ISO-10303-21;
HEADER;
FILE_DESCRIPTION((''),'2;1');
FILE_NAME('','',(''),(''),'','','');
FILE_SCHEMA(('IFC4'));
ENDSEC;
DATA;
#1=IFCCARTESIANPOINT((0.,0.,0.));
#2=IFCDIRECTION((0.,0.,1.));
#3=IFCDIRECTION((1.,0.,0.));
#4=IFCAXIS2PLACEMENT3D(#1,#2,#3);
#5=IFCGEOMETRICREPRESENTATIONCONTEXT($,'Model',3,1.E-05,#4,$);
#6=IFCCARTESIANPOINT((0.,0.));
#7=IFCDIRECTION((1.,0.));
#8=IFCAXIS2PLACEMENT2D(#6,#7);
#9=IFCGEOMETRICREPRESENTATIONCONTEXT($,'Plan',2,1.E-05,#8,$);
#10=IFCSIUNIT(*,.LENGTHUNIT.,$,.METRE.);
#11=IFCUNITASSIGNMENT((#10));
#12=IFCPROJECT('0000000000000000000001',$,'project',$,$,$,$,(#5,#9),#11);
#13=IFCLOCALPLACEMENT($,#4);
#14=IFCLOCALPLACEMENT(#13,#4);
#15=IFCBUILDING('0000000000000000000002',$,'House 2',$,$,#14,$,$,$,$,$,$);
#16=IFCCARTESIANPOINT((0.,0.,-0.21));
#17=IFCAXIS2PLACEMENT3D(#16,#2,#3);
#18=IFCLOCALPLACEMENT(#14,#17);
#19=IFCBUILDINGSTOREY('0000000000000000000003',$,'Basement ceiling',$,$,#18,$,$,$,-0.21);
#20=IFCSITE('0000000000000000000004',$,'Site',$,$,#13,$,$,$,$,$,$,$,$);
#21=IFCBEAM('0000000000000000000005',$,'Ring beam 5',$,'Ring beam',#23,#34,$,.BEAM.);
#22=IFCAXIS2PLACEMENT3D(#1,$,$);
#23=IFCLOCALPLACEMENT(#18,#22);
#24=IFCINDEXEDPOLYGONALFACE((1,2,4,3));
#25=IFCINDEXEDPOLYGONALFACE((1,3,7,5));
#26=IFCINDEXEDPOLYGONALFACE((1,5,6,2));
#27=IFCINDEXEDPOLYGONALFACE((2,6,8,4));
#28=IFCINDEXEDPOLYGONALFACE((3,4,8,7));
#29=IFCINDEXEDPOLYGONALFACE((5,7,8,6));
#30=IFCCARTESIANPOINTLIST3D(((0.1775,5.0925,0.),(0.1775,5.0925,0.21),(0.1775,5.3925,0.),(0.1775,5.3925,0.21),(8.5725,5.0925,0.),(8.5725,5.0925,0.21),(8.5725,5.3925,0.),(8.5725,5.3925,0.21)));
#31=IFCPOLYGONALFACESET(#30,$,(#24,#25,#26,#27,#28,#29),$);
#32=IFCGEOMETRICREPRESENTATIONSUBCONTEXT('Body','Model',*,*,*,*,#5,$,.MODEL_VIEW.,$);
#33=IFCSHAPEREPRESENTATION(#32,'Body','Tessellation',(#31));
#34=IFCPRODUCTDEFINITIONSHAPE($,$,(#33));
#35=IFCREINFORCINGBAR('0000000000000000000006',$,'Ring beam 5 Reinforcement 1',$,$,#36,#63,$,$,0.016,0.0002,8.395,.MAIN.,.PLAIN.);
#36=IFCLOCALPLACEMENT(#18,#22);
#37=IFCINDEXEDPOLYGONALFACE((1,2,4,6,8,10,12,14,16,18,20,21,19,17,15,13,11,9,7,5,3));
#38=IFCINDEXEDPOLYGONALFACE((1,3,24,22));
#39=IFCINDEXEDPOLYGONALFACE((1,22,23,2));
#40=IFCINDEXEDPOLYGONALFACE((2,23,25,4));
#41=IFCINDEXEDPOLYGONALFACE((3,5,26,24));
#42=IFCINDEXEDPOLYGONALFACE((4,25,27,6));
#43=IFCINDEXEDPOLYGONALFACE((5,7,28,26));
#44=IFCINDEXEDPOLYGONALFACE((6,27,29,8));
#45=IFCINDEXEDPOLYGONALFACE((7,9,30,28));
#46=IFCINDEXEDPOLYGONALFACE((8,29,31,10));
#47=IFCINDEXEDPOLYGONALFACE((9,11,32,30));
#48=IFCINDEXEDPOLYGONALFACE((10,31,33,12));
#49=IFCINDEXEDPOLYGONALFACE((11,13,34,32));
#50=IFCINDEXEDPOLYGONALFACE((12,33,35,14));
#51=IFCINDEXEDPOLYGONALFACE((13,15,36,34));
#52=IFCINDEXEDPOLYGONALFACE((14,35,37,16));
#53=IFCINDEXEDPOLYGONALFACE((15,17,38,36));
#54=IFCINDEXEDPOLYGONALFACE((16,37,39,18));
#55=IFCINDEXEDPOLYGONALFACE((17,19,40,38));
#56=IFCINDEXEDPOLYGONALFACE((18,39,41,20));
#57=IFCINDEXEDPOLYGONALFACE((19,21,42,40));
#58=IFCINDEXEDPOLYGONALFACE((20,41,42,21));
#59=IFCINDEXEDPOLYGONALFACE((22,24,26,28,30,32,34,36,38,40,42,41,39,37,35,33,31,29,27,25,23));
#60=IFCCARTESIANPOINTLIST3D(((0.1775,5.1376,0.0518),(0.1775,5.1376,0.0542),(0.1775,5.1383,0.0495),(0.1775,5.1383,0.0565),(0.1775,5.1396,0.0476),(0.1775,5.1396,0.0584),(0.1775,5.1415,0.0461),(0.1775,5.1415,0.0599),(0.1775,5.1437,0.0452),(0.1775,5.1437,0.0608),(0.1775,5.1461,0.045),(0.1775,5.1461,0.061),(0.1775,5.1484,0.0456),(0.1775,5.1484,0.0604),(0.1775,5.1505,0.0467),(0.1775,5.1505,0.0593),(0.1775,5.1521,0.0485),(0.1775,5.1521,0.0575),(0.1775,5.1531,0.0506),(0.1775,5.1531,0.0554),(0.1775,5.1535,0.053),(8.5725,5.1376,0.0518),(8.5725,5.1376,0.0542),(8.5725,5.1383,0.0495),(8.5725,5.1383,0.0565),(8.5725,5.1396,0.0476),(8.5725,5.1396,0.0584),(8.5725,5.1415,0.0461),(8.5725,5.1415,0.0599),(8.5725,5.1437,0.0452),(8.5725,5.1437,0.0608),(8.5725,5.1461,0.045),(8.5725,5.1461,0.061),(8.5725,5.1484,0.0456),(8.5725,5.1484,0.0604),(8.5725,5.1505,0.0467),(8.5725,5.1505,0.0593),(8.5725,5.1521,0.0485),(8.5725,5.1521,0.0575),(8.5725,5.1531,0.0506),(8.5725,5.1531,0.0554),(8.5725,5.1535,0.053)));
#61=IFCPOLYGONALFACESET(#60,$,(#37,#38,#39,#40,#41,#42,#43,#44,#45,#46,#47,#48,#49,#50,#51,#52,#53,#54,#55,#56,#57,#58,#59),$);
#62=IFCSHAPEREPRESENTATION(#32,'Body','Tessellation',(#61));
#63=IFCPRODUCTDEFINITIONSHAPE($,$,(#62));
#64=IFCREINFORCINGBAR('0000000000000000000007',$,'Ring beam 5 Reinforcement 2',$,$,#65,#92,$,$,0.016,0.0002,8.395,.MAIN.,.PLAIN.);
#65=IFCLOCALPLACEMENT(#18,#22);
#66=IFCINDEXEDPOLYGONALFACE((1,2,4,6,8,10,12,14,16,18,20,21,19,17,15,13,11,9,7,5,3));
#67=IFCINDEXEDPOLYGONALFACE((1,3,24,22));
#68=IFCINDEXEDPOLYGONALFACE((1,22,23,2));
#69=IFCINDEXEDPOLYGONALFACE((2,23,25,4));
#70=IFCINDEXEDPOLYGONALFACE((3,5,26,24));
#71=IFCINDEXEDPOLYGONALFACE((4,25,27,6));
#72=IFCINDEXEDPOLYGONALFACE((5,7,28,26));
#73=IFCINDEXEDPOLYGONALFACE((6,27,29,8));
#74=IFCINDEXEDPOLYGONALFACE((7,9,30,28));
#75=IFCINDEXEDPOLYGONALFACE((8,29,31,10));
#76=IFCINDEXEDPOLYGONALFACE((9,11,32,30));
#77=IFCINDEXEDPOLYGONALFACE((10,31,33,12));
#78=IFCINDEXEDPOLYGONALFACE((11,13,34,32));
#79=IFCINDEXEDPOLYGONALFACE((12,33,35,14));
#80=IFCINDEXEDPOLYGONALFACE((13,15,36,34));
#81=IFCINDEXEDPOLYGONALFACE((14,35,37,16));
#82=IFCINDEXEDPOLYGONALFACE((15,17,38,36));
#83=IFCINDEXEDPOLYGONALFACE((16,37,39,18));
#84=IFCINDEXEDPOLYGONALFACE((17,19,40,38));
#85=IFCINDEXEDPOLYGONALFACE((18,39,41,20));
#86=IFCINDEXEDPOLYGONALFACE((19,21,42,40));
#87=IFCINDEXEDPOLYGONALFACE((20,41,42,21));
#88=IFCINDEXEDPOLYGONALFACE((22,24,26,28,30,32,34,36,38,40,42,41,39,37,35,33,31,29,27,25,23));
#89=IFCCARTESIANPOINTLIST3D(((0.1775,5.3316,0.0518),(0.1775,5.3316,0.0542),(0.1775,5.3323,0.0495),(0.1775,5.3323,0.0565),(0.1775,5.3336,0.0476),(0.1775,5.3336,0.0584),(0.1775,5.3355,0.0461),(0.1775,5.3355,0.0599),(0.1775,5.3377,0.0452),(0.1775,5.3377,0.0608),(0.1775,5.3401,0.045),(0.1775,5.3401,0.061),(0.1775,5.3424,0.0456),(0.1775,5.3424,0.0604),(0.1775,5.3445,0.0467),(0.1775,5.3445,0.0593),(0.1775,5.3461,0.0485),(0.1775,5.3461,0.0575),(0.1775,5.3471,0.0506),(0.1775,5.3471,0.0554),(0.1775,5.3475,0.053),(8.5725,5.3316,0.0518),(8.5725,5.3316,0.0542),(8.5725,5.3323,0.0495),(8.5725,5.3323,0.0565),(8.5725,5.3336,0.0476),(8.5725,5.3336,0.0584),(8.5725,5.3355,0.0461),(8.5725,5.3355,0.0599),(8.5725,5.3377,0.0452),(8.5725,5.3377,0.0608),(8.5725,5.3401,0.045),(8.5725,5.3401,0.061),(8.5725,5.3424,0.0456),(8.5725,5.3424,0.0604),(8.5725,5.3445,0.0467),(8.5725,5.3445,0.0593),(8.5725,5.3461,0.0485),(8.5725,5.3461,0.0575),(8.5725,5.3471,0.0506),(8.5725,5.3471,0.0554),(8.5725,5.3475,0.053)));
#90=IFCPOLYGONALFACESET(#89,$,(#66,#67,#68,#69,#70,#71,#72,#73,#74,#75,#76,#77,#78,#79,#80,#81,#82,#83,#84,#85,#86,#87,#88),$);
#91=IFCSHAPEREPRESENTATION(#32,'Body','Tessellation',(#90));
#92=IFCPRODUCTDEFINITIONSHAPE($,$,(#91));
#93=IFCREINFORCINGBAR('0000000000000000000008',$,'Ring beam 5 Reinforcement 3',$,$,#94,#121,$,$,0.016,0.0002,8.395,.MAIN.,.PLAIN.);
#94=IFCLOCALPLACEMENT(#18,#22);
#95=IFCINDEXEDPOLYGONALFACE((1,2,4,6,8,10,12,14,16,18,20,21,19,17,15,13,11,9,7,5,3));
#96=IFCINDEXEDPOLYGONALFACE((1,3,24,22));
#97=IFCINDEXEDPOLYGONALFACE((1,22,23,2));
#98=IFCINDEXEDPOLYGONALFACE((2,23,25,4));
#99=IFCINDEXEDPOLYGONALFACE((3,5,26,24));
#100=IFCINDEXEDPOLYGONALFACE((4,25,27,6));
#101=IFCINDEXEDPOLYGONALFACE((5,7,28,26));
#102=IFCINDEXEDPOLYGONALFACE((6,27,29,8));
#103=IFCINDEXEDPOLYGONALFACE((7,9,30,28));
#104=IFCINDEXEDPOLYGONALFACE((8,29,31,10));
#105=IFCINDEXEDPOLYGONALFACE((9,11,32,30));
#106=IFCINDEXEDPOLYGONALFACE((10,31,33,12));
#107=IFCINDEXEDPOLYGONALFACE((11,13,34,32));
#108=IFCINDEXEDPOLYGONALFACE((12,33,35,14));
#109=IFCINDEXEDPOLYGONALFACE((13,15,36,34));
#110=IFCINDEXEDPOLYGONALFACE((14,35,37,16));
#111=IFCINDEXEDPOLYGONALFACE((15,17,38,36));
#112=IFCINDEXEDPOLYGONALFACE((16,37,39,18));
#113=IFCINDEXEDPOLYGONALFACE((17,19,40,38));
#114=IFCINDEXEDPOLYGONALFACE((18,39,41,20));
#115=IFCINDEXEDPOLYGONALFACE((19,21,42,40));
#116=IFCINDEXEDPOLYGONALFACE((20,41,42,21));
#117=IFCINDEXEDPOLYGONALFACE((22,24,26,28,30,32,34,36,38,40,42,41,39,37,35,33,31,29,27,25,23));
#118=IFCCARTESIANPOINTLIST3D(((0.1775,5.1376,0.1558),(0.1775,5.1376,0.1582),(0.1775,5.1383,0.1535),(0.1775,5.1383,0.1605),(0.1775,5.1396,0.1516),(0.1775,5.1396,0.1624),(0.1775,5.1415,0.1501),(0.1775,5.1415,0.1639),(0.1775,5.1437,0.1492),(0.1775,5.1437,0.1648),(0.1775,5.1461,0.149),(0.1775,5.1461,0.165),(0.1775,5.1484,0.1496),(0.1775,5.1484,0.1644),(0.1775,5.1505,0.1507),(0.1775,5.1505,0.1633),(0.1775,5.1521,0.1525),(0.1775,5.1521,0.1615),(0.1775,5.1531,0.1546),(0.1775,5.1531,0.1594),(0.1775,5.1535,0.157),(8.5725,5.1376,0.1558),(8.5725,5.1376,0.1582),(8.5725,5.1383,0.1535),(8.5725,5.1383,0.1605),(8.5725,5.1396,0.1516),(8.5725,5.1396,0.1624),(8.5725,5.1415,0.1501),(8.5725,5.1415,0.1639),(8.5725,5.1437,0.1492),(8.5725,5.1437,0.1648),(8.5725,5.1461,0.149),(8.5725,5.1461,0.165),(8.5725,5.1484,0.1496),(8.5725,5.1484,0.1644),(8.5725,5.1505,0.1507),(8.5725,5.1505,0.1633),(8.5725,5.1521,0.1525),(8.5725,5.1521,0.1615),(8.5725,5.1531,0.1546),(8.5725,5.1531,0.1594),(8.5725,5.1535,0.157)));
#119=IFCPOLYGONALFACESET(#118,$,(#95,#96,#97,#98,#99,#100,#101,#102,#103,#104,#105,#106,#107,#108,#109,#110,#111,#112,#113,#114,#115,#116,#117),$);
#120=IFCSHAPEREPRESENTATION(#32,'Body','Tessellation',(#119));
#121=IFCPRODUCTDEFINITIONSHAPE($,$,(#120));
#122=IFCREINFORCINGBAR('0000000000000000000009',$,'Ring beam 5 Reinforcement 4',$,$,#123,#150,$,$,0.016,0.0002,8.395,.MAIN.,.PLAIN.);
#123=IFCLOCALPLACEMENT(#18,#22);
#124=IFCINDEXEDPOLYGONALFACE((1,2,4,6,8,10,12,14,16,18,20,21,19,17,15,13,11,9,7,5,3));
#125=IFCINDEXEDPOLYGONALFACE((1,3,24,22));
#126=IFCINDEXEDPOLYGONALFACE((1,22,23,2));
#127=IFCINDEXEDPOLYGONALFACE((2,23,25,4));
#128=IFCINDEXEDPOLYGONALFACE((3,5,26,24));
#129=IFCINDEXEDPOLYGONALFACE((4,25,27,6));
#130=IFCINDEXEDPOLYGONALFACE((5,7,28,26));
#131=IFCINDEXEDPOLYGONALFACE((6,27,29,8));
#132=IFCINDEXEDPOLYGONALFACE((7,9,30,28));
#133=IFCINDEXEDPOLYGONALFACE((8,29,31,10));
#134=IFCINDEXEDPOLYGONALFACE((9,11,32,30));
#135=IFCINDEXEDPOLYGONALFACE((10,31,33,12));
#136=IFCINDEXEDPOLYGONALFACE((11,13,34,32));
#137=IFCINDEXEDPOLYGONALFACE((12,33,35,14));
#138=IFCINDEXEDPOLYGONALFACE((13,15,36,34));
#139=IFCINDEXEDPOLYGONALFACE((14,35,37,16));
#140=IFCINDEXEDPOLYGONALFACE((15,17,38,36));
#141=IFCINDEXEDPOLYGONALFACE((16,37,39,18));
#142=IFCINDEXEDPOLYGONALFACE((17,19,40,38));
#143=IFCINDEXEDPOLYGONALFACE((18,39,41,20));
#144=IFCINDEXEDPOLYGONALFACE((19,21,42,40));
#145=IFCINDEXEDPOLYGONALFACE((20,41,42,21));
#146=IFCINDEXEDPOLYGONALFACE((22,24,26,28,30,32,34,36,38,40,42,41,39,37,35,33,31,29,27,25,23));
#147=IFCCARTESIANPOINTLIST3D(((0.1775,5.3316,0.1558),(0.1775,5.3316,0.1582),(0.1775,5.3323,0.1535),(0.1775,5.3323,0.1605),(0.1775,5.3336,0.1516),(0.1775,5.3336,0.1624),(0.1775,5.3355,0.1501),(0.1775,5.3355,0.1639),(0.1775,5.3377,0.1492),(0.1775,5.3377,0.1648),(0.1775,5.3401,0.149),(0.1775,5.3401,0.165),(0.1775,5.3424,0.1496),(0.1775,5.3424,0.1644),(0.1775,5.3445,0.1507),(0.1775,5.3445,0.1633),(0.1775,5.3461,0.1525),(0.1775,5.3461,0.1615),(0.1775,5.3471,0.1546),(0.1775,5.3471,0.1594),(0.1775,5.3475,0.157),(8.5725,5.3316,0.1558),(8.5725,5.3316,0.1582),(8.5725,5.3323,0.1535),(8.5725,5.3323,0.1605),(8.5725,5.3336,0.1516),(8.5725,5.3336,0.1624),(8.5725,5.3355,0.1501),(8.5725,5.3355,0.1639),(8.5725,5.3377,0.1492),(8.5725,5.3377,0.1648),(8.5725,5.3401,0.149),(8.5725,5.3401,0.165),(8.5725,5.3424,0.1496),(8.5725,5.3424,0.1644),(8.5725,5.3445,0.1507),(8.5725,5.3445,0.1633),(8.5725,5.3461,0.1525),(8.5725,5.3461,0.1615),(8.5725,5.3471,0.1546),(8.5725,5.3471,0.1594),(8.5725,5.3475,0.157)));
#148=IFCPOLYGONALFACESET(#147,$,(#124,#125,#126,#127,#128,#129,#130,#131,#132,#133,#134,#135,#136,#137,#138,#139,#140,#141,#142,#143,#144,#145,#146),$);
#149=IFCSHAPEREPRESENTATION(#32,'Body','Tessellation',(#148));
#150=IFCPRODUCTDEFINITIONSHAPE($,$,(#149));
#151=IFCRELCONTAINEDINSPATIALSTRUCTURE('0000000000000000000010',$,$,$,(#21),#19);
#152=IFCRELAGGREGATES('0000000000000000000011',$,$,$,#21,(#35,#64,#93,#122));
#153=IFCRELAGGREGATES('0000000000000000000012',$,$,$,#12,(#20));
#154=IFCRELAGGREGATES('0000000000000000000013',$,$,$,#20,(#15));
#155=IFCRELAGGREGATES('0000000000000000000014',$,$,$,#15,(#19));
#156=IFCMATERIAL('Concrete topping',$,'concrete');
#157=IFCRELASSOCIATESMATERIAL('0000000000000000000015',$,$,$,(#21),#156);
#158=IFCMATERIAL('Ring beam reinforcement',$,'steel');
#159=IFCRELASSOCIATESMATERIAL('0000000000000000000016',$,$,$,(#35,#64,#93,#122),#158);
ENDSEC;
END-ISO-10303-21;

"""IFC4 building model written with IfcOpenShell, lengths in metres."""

from ifc_helpers import new_model, si_unit, frame, origin_with_axes, origin_2d, origin_2d_with_axis, place, context, subcontext, project, spatial, circle_curve, rectangle, outline, extrude, material, element, aggregate, save


model = new_model("IFC4")

# Units and contexts
model_context = context("Model", 3, precision=1e-05, world=origin_with_axes())
plan_context = context("Plan", 2, precision=1e-05, world=origin_2d_with_axis())
body_context = subcontext(model_context, "Body", "Model", "MODEL_VIEW")
ifc_project = project(units=[si_unit("LENGTHUNIT", "METRE")], contexts=[model_context, plan_context])

# Site, building, storey
site_placement = place(None, origin_with_axes())
site = spatial("IfcSite", under=ifc_project, at=site_placement, Name="Site")
building_placement = place(site_placement, origin_with_axes())
building = spatial("IfcBuilding", under=site, at=building_placement, Name="House 2")
storey_placement = place(building_placement, frame((0.0, 0.0, -0.21), z_axis=(0.0, 0.0, 1.0), x_axis=(1.0, 0.0, 0.0)))
storey = spatial("IfcBuildingStorey", under=building, at=storey_placement, Name="Basement ceiling", Elevation=-0.21)

# Beam
ifc_material_1 = material(Name="Concrete topping", Category="concrete")
beam_1_placement = place(storey_placement, frame((0.1775, 5.2425, 0.105), z_axis=(0.0, 0.0, 1.0), x_axis=(1.0, 0.0, 0.0)))
beam_1 = element("IfcBeam", 1, at=beam_1_placement, inside=storey, material=ifc_material_1, Name="Ring beam 5", ObjectType="Ring beam", PredefinedType="BEAM", context=body_context, shape_type="SweptSolid", body=[
    extrude(rectangle(XDim=0.3, YDim=0.21), frame((0.0, 0.0, 0.0), z_axis=(1.0, 0.0, 0.0), x_axis=(0.0, 1.0, 0.0)), (0.0, 0.0, 1.0), 8.395),
])

# Reinforcing bars
ifc_material_2 = material(Name="Ring beam reinforcement", Category="steel")
reinforcing_bar_1_placement = place(beam_1_placement, frame((0.0, -0.097, -0.052), z_axis=(0.0, 0.0, 1.0), x_axis=(1.0, 0.0, 0.0)))
reinforcing_bar_1 = element("IfcReinforcingBar", 2, at=reinforcing_bar_1_placement, material=ifc_material_2, Name="Ring beam 5 Reinforcement 1", BarLength=8.395, BarSurface="PLAIN", CrossSectionArea=0.0002, NominalDiameter=0.016, PredefinedType="MAIN", context=body_context, shape_type="SweptSolid", body=[
    extrude(outline(circle_curve(origin_2d(), 0.008)), frame((0.0, 0.0, 0.0), z_axis=(1.0, 0.0, 0.0), x_axis=(0.0, 1.0, 0.0)), (0.0, 0.0, 1.0), 8.395),
])
reinforcing_bar_2_placement = place(beam_1_placement, frame((0.0, 0.097, -0.052), z_axis=(0.0, 0.0, 1.0), x_axis=(1.0, 0.0, 0.0)))
reinforcing_bar_2 = element("IfcReinforcingBar", 3, at=reinforcing_bar_2_placement, material=ifc_material_2, Name="Ring beam 5 Reinforcement 2", BarLength=8.395, BarSurface="PLAIN", CrossSectionArea=0.0002, NominalDiameter=0.016, PredefinedType="MAIN", context=body_context, shape_type="SweptSolid", body=[
    extrude(outline(circle_curve(origin_2d(), 0.008)), frame((0.0, 0.0, 0.0), z_axis=(1.0, 0.0, 0.0), x_axis=(0.0, 1.0, 0.0)), (0.0, 0.0, 1.0), 8.395),
])
reinforcing_bar_3_placement = place(beam_1_placement, frame((0.0, -0.097, 0.052), z_axis=(0.0, 0.0, 1.0), x_axis=(1.0, 0.0, 0.0)))
reinforcing_bar_3 = element("IfcReinforcingBar", 4, at=reinforcing_bar_3_placement, material=ifc_material_2, Name="Ring beam 5 Reinforcement 3", BarLength=8.395, BarSurface="PLAIN", CrossSectionArea=0.0002, NominalDiameter=0.016, PredefinedType="MAIN", context=body_context, shape_type="SweptSolid", body=[
    extrude(outline(circle_curve(origin_2d(), 0.008)), frame((0.0, 0.0, 0.0), z_axis=(1.0, 0.0, 0.0), x_axis=(0.0, 1.0, 0.0)), (0.0, 0.0, 1.0), 8.395),
])
reinforcing_bar_4_placement = place(beam_1_placement, frame((0.0, 0.097, 0.052), z_axis=(0.0, 0.0, 1.0), x_axis=(1.0, 0.0, 0.0)))
reinforcing_bar_4 = element("IfcReinforcingBar", 5, at=reinforcing_bar_4_placement, material=ifc_material_2, Name="Ring beam 5 Reinforcement 4", BarLength=8.395, BarSurface="PLAIN", CrossSectionArea=0.0002, NominalDiameter=0.016, PredefinedType="MAIN", context=body_context, shape_type="SweptSolid", body=[
    extrude(outline(circle_curve(origin_2d(), 0.008)), frame((0.0, 0.0, 0.0), z_axis=(1.0, 0.0, 0.0), x_axis=(0.0, 1.0, 0.0)), (0.0, 0.0, 1.0), 8.395),
])
aggregate(beam_1, [reinforcing_bar_1, reinforcing_bar_2, reinforcing_bar_3, reinforcing_bar_4])

save(model, "model.ifc")
